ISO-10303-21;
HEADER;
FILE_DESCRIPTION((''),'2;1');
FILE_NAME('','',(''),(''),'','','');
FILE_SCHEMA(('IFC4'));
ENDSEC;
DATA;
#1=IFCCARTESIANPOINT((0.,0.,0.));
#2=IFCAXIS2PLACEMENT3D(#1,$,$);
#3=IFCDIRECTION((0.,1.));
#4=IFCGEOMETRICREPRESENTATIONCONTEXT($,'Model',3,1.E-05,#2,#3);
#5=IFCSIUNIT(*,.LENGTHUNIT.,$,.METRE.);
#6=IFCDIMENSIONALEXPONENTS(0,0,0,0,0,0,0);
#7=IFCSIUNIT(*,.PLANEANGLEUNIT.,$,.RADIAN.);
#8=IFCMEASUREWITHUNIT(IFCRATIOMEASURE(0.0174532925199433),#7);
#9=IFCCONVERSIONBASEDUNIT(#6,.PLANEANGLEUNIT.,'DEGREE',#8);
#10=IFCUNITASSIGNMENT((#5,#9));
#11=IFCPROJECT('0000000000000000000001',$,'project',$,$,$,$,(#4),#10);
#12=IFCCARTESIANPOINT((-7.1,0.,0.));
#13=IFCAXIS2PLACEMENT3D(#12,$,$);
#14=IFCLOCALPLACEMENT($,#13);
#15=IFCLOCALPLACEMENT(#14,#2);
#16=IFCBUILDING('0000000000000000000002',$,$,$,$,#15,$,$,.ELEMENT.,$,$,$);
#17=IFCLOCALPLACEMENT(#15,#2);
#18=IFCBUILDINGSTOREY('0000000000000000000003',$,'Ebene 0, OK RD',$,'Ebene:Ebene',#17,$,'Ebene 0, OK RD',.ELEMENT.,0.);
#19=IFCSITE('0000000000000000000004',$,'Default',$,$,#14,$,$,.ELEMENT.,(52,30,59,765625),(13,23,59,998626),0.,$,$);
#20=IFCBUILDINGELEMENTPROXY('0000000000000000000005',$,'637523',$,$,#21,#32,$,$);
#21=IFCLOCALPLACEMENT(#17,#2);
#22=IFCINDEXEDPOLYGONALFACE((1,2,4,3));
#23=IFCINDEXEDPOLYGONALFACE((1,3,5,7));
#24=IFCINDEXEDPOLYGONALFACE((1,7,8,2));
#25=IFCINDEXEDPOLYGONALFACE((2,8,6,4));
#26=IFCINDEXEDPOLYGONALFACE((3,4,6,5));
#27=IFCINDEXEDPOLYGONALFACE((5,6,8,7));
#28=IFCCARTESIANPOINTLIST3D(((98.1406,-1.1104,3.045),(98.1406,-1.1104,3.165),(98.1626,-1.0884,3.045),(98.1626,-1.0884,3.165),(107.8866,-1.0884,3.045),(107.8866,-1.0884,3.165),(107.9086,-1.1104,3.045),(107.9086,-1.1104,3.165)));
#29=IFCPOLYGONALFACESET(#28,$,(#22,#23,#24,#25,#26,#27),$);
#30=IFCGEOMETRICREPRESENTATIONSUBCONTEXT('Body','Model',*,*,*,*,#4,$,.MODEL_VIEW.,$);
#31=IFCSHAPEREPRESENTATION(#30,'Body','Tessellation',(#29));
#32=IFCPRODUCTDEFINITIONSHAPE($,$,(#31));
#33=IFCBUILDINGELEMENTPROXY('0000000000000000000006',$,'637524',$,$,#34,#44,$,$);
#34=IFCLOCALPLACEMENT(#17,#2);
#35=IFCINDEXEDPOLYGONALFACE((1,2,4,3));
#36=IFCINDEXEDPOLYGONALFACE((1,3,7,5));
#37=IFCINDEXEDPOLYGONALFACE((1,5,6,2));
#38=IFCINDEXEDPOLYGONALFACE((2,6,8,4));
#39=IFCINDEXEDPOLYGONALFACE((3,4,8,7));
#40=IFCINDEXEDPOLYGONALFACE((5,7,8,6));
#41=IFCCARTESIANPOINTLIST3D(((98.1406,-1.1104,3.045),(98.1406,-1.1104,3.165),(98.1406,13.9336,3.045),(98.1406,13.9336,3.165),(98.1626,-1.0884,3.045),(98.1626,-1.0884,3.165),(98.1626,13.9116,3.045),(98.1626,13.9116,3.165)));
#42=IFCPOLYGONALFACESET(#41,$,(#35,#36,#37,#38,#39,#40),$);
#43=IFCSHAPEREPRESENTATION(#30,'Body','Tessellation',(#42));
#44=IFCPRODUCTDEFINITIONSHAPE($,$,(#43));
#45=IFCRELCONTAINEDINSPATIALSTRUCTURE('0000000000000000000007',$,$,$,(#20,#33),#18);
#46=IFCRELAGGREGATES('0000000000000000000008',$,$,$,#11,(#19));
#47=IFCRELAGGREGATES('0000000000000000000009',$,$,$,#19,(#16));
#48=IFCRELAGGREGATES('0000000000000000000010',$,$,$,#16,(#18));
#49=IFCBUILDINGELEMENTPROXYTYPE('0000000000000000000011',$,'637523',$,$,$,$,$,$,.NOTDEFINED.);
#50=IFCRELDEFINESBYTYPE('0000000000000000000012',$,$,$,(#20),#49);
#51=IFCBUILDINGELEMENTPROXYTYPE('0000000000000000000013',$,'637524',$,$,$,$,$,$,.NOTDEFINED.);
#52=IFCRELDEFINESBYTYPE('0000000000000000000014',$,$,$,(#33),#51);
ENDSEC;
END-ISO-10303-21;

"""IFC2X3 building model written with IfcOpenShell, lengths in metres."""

from ifc_helpers import new_model, entity, si_unit, converted_unit, direction, frame, origin, place, context, subcontext, project, spatial, polyline, outline, extrude, type_object, element, save


model = new_model("IFC2X3")

# Units and contexts
model_context = context("Model", 3, precision=1e-05, world=origin(), true_north=direction((0.0, 1.0)))
body_context = subcontext(model_context, "Body", "Model", "MODEL_VIEW")
ifc_project = project(units=[si_unit("LENGTHUNIT", "METRE"), converted_unit("PLANEANGLEUNIT", "DEGREE", entity("IfcRatioMeasure", 0.0174532925199433), si_unit("PLANEANGLEUNIT", "RADIAN"), dimensions=[0, 0, 0, 0, 0, 0, 0])], contexts=[model_context])

# Site, building, storey
site_placement = place(None, frame((-7.1, 0.0, 0.0)))
site = spatial("IfcSite", under=ifc_project, at=site_placement, Name="Default", CompositionType="ELEMENT", RefLatitude=(52, 30, 59, 765625), RefLongitude=(13, 23, 59, 998626), RefElevation=0.0)
building_placement = place(site_placement, origin())
building = spatial("IfcBuilding", under=site, at=building_placement, CompositionType="ELEMENT")
storey_placement = place(building_placement, origin())
storey = spatial("IfcBuildingStorey", under=building, at=storey_placement, Name="Ebene 0, OK RD", ObjectType="Ebene:Ebene", LongName="Ebene 0, OK RD", CompositionType="ELEMENT", Elevation=0.0)

# Building element proxies
building_element_proxy_type_1 = type_object("IfcBuildingElementProxyType", Name="637523", PredefinedType="NOTDEFINED")
proxy_1_placement = place(storey_placement, origin())
element("IfcBuildingElementProxy", 1, at=proxy_1_placement, inside=storey, type_object=building_element_proxy_type_1, Name="637523", context=body_context, shape_type="SweptSolid", body=[
    extrude(outline(polyline([(-4.862, -0.011), (4.862, -0.011), (4.884, 0.011), (-4.884, 0.011), (-4.862, -0.011)])), frame((103.0246, -1.0994, 3.045), z_axis=(0.0, 0.0, 1.0), x_axis=(-1.0, 0.0, 0.0)), (0.0, 0.0, 1.0), 0.12),
])
building_element_proxy_type_2 = type_object("IfcBuildingElementProxyType", Name="637524", PredefinedType="NOTDEFINED")
proxy_2_placement = place(storey_placement, origin())
element("IfcBuildingElementProxy", 2, at=proxy_2_placement, inside=storey, type_object=building_element_proxy_type_2, Name="637524", context=body_context, shape_type="SweptSolid", body=[
    extrude(outline(polyline([(-7.5, -0.011), (7.5, -0.011), (7.522, 0.011), (-7.522, 0.011), (-7.5, -0.011)])), frame((98.1516, 6.4116, 3.045), z_axis=(0.0, 0.0, 1.0), x_axis=(0.0, 1.0, 0.0)), (0.0, 0.0, 1.0), 0.12),
])

save(model, "model.ifc")
